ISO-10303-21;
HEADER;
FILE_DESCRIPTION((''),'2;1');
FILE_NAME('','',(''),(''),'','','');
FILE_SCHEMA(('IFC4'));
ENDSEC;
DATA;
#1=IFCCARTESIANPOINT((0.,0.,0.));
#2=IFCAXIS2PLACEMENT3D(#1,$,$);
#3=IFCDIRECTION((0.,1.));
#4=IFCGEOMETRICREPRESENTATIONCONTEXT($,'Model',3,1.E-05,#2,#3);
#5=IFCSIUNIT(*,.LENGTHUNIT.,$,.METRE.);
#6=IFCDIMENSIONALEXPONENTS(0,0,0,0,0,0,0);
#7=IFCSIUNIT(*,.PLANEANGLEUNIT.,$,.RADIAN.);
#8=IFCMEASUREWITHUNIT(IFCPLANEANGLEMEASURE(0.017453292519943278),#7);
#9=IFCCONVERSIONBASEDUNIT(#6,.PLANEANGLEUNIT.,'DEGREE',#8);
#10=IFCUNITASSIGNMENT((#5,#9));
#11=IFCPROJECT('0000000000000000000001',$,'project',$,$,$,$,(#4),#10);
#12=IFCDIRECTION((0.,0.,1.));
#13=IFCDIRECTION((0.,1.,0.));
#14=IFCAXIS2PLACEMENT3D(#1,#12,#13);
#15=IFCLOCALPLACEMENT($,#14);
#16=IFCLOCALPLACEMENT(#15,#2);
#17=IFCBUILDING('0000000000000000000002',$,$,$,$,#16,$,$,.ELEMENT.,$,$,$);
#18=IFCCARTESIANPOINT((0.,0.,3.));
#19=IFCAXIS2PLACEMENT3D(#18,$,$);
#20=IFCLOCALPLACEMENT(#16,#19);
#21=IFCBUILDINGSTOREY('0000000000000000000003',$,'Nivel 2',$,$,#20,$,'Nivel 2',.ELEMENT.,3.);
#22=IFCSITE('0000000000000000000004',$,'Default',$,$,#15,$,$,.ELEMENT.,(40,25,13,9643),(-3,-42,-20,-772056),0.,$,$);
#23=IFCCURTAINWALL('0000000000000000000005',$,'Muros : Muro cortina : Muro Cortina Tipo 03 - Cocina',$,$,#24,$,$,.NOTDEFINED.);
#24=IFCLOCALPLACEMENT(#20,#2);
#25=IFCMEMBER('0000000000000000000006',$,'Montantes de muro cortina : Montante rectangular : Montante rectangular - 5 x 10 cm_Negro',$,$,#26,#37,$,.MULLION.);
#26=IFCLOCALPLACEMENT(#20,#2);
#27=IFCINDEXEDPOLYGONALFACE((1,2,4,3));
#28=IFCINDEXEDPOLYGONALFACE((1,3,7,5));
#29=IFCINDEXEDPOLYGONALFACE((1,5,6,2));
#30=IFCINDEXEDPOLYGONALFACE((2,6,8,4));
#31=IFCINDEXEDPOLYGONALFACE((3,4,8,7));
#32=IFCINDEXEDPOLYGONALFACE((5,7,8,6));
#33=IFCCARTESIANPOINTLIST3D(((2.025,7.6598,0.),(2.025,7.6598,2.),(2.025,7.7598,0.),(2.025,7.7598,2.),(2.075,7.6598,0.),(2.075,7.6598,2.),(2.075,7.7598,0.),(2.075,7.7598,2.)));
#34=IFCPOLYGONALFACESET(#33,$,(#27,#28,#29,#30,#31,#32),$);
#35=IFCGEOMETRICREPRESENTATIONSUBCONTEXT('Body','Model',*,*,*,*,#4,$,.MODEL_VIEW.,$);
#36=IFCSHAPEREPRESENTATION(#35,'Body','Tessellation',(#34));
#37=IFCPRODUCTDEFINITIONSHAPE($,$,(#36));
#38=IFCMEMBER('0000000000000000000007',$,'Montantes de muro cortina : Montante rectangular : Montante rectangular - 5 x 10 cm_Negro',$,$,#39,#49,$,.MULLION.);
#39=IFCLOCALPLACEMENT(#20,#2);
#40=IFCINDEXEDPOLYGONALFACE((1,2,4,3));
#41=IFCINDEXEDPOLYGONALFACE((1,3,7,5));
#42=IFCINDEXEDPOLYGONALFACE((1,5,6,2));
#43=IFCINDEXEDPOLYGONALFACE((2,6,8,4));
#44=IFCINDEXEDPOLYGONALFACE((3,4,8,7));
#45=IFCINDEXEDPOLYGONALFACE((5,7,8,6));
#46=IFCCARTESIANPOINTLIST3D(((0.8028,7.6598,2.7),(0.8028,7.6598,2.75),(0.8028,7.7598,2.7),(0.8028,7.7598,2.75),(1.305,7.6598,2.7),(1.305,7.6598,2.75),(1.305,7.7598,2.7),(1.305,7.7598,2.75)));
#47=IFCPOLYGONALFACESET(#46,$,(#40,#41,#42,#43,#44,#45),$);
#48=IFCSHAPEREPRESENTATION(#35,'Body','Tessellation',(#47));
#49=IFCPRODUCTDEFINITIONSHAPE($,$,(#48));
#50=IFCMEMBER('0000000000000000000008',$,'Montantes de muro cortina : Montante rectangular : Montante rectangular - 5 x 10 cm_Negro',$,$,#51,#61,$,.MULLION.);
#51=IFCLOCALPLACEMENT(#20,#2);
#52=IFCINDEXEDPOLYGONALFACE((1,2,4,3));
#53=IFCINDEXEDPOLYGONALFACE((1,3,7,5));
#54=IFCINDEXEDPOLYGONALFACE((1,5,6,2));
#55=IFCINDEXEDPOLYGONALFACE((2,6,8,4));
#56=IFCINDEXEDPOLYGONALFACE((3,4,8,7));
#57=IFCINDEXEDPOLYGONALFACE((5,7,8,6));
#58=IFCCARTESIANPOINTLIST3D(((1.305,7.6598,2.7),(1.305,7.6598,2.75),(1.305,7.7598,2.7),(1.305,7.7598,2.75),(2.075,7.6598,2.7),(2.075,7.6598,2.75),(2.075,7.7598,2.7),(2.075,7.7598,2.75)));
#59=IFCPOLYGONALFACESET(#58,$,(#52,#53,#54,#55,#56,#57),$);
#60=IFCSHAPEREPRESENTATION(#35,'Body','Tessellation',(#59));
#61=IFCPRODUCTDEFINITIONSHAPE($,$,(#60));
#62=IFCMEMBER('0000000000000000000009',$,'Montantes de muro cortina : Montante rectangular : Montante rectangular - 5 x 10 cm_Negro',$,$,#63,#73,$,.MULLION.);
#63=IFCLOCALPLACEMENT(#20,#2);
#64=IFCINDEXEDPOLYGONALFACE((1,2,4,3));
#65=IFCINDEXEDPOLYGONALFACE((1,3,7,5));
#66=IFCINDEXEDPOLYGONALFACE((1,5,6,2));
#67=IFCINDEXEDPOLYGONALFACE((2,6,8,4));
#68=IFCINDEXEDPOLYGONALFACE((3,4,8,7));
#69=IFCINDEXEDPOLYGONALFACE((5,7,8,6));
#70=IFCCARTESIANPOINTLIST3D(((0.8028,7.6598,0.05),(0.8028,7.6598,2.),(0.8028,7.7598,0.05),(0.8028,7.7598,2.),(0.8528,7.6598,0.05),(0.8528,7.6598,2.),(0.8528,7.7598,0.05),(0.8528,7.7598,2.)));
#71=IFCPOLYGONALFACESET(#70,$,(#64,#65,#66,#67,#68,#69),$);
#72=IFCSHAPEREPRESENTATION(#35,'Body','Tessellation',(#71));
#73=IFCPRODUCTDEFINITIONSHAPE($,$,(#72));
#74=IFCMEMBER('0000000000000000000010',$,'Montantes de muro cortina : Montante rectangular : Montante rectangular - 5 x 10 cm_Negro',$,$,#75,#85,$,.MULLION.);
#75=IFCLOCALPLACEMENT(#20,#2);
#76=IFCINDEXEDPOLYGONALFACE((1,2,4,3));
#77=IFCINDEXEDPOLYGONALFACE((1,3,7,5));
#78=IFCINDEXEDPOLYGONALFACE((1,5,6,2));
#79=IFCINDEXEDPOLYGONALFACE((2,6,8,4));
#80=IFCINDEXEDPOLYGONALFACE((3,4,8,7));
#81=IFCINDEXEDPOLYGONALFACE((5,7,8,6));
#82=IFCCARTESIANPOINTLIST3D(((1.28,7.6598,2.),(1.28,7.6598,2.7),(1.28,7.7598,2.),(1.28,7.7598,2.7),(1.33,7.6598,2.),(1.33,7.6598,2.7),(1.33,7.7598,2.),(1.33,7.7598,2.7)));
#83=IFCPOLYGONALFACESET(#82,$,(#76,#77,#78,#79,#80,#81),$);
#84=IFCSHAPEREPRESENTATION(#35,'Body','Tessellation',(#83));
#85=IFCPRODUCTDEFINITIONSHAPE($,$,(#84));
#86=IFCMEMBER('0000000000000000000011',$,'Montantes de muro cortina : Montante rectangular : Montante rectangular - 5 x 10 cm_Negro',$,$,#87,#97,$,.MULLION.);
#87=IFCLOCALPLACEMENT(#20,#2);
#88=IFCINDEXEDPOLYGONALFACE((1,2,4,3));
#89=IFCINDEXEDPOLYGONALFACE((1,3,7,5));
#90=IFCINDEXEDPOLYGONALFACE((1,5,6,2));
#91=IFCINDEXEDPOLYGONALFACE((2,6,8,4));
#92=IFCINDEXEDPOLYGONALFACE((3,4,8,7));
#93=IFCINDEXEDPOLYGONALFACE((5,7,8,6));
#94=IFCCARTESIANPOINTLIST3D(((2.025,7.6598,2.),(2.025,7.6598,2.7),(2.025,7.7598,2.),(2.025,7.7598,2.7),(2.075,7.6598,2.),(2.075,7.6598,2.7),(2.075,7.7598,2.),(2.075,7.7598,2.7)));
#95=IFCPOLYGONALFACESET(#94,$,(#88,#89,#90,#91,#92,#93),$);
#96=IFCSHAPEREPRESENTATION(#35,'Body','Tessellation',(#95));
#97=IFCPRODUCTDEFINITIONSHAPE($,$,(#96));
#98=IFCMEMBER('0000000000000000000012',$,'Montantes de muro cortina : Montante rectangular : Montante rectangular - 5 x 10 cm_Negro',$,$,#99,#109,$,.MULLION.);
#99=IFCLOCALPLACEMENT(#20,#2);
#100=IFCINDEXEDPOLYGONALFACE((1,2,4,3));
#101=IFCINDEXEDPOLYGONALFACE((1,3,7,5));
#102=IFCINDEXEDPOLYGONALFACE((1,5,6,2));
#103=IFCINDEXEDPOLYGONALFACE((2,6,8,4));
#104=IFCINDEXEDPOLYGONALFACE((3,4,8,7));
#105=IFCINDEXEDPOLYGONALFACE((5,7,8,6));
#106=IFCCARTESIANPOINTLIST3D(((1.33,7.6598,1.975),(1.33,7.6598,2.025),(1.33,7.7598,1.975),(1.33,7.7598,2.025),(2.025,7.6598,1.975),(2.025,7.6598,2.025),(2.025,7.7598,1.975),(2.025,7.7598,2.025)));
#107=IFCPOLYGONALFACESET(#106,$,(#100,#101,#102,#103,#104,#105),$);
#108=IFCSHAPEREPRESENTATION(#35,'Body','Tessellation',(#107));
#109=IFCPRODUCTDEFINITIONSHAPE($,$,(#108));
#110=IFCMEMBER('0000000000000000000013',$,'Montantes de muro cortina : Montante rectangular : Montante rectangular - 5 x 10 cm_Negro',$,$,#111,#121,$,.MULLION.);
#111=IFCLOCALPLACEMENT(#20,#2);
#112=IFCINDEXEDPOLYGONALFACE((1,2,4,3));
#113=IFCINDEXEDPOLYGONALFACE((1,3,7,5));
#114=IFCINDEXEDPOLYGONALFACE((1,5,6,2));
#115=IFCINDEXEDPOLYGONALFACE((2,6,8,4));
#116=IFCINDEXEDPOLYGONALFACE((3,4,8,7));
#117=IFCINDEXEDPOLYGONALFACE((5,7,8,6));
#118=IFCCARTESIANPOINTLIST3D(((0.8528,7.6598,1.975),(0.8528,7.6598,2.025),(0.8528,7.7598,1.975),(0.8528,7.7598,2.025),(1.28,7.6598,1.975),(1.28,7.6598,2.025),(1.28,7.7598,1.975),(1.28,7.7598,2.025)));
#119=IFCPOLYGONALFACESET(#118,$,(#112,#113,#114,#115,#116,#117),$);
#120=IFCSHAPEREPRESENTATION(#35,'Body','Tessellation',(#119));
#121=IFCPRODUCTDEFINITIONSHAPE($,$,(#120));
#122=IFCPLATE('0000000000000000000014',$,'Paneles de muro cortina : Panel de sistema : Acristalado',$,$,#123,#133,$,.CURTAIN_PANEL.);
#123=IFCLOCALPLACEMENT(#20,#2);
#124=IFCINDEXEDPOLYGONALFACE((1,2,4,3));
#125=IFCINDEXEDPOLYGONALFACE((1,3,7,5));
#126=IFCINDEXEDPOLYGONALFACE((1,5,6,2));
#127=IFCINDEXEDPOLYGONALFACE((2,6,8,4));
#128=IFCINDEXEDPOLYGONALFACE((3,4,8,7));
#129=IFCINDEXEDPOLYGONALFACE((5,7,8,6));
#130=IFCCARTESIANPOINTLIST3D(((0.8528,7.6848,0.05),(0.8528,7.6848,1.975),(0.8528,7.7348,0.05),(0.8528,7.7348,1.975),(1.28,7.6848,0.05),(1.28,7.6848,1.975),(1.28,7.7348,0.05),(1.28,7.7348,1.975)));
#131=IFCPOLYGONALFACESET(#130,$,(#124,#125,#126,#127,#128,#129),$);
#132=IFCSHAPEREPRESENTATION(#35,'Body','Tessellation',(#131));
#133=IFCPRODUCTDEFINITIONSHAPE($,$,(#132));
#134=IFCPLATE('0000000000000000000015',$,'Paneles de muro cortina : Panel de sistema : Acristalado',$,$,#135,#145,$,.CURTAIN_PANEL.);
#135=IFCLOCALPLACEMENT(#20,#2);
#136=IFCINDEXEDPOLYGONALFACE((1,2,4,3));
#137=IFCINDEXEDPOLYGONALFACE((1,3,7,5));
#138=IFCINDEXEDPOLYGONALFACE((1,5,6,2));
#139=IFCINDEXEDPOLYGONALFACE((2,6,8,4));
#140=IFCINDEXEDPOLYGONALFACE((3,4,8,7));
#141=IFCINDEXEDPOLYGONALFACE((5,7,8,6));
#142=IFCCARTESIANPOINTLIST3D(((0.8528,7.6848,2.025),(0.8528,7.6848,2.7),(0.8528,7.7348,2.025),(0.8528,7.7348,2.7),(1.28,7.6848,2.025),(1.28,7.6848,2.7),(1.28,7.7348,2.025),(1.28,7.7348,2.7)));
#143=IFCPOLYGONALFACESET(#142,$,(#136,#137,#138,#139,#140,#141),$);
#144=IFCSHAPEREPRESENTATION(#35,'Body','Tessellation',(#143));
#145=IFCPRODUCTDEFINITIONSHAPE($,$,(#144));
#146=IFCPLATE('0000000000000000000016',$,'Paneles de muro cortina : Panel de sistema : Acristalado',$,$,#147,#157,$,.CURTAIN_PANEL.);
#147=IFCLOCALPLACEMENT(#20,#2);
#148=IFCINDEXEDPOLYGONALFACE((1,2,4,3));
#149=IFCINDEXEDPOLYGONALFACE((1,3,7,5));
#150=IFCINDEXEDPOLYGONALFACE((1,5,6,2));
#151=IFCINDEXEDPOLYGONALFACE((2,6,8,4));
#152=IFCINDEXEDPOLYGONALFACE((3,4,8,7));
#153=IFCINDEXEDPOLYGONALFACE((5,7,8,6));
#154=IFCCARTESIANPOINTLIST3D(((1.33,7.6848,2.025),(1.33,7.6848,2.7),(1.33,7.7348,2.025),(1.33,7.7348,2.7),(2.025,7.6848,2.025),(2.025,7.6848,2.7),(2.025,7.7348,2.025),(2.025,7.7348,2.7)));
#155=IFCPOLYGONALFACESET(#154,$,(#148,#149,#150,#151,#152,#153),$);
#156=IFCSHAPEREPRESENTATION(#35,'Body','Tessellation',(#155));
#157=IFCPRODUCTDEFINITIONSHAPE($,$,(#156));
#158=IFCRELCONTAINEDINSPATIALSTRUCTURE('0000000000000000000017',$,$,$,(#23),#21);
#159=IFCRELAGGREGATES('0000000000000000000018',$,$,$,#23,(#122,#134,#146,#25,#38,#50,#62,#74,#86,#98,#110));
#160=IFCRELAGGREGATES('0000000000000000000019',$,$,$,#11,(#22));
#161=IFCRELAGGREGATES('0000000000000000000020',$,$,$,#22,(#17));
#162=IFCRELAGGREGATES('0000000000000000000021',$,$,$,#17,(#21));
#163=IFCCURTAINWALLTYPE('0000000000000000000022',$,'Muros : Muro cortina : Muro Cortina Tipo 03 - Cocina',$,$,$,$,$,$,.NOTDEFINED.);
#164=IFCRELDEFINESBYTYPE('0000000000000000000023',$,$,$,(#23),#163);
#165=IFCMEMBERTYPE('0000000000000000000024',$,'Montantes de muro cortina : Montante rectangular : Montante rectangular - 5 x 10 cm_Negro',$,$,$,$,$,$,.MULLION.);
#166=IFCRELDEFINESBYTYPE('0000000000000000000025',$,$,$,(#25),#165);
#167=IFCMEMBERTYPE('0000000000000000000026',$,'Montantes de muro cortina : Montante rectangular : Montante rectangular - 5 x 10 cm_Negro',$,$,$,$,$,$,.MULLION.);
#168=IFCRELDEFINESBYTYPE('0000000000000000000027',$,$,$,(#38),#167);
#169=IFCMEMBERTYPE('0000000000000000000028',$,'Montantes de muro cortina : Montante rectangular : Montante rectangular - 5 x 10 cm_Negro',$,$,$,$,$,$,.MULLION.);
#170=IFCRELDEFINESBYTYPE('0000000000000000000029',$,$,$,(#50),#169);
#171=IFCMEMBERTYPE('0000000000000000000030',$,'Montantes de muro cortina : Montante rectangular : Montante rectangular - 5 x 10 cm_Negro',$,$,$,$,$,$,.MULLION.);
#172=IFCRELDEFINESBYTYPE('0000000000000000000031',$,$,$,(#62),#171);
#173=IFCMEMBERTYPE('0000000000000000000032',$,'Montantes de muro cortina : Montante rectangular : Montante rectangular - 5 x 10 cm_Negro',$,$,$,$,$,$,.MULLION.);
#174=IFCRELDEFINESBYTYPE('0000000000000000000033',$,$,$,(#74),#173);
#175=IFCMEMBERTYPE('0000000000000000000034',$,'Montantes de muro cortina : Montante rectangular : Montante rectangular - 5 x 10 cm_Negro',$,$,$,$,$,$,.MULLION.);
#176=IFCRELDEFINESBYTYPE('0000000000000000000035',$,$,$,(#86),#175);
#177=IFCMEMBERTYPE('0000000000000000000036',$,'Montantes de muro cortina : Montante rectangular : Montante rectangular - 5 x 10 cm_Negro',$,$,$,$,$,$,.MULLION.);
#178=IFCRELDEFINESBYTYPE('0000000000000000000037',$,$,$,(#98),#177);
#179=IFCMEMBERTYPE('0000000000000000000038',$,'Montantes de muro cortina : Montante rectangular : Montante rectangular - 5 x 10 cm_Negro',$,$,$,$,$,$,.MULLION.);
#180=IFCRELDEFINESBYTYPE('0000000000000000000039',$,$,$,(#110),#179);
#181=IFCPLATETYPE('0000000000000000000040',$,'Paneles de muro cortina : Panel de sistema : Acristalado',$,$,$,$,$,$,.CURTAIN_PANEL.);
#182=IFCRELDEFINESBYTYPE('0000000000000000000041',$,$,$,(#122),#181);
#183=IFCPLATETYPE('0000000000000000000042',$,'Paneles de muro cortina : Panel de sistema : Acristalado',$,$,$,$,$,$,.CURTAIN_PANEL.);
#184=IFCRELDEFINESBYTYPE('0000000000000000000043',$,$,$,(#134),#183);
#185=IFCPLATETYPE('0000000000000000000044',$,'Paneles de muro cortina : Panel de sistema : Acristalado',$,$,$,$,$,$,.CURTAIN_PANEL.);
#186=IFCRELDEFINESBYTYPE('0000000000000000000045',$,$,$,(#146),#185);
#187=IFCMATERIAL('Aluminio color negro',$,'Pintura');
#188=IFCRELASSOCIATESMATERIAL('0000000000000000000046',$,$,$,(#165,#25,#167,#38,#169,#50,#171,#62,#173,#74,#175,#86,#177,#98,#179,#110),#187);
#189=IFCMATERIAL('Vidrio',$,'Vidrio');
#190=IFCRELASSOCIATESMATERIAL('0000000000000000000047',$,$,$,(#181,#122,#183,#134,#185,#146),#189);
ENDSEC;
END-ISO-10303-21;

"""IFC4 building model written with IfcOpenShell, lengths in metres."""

from ifc_helpers import new_model, entity, si_unit, converted_unit, direction, frame, origin, place, context, subcontext, project, spatial, indexed_curve, outline, extrude, source, transform, mapped, material, type_object, type_shapes, element, aggregate, save


model = new_model("IFC4")

# Units and contexts
model_context = context("Model", 3, precision=1e-05, world=origin(), true_north=direction((0.0, 1.0)))
body_context = subcontext(model_context, "Body", "Model", "MODEL_VIEW")
ifc_project = project(units=[si_unit("LENGTHUNIT", "METRE"), converted_unit("PLANEANGLEUNIT", "DEGREE", entity("IfcPlaneAngleMeasure", 0.017453292519943278), si_unit("PLANEANGLEUNIT", "RADIAN"), dimensions=[0, 0, 0, 0, 0, 0, 0])], contexts=[model_context])

# Site, building, storey
site_placement = place(None, frame((0.0, 0.0, 0.0), z_axis=(0.0, 0.0, 1.0), x_axis=(0.0, 1.0, 0.0)))
site = spatial("IfcSite", under=ifc_project, at=site_placement, Name="Default", CompositionType="ELEMENT", RefLatitude=(40, 25, 13, 9643), RefLongitude=(-3, -42, -20, -772056), RefElevation=0.0)
building_placement = place(site_placement, origin())
building = spatial("IfcBuilding", under=site, at=building_placement, CompositionType="ELEMENT")
storey_placement = place(building_placement, frame((0.0, 0.0, 3.0)))
storey = spatial("IfcBuildingStorey", under=building, at=storey_placement, Name="Nivel 2", LongName="Nivel 2", CompositionType="ELEMENT", Elevation=3.0)

# Curtain wall, members, plates
curtain_wall_type_1 = type_object("IfcCurtainWallType", Name="Muros : Muro cortina : Muro Cortina Tipo 03 - Cocina", PredefinedType="NOTDEFINED")
curtain_wall_1_placement = place(storey_placement, frame((0.0, 0.0, -3.0)))
curtain_wall_1 = element("IfcCurtainWall", 1, at=curtain_wall_1_placement, inside=storey, type_object=curtain_wall_type_1, Name="Muros : Muro cortina : Muro Cortina Tipo 03 - Cocina", PredefinedType="NOTDEFINED")
ifc_material_1 = material(Name="Aluminio color negro", Category="Pintura")
member_type_1 = type_object("IfcMemberType", Name="Montantes de muro cortina : Montante rectangular : Montante rectangular - 5 x 10 cm_Negro", PredefinedType="MULLION", material=ifc_material_1)
shared_shape_1 = source(origin(), body_context, "Body", "SweptSolid", [
    extrude(outline(indexed_curve([(-0.025, -0.05), (0.025, -0.05), (0.025, 0.05), (-0.025, 0.05), (-0.025, -0.05)], self_intersect=False)), frame((-0.025, 0.0, -2.0), z_axis=(0.0, 0.0, 1.0), x_axis=(-1.0, 0.0, 0.0)), (0.0, 0.0, 1.0), 2.0),
])
type_shapes(member_type_1, [shared_shape_1])
member_1_placement = place(curtain_wall_1_placement, frame((2.075, 7.7098, 3.0), z_axis=(0.0, 0.0, -1.0), x_axis=(1.0, 0.0, 0.0)))
member_1 = element("IfcMember", 2, at=member_1_placement, type_object=member_type_1, material=ifc_material_1, Name="Montantes de muro cortina : Montante rectangular : Montante rectangular - 5 x 10 cm_Negro", PredefinedType="MULLION", context=body_context, shape_type="MappedRepresentation", body=[
    mapped(shared_shape_1, transform((0.0, 0.0, 0.0), scale=1.0)),
])
member_type_2 = type_object("IfcMemberType", Name="Montantes de muro cortina : Montante rectangular : Montante rectangular - 5 x 10 cm_Negro", PredefinedType="MULLION", material=ifc_material_1)
shared_shape_2 = source(origin(), body_context, "Body", "SweptSolid", [
    extrude(outline(indexed_curve([(-0.025, -0.05), (0.025, -0.05), (0.025, 0.05), (-0.025, 0.05), (-0.025, -0.05)], self_intersect=False)), frame((-0.025, 0.0, -0.5022), z_axis=(0.0, 0.0, 1.0), x_axis=(-1.0, 0.0, 0.0)), (0.0, 0.0, 1.0), 0.5022),
])
type_shapes(member_type_2, [shared_shape_2])
member_2_placement = place(curtain_wall_1_placement, frame((1.305, 7.7098, 5.75), z_axis=(1.0, 0.0, 0.0), x_axis=(0.0, 0.0, 1.0)))
member_2 = element("IfcMember", 3, at=member_2_placement, type_object=member_type_2, material=ifc_material_1, Name="Montantes de muro cortina : Montante rectangular : Montante rectangular - 5 x 10 cm_Negro", PredefinedType="MULLION", context=body_context, shape_type="MappedRepresentation", body=[
    mapped(shared_shape_2, transform((0.0, 0.0, 0.0), scale=1.0)),
])
member_type_3 = type_object("IfcMemberType", Name="Montantes de muro cortina : Montante rectangular : Montante rectangular - 5 x 10 cm_Negro", PredefinedType="MULLION", material=ifc_material_1)
shared_shape_3 = source(origin(), body_context, "Body", "SweptSolid", [
    extrude(outline(indexed_curve([(-0.025, -0.05), (0.025, -0.05), (0.025, 0.05), (-0.025, 0.05), (-0.025, -0.05)], self_intersect=False)), frame((-0.025, 0.0, -0.77), z_axis=(0.0, 0.0, 1.0), x_axis=(-1.0, 0.0, 0.0)), (0.0, 0.0, 1.0), 0.77),
])
type_shapes(member_type_3, [shared_shape_3])
member_3_placement = place(curtain_wall_1_placement, frame((2.075, 7.7098, 5.75), z_axis=(1.0, 0.0, 0.0), x_axis=(0.0, 0.0, 1.0)))
member_3 = element("IfcMember", 4, at=member_3_placement, type_object=member_type_3, material=ifc_material_1, Name="Montantes de muro cortina : Montante rectangular : Montante rectangular - 5 x 10 cm_Negro", PredefinedType="MULLION", context=body_context, shape_type="MappedRepresentation", body=[
    mapped(shared_shape_3, transform((0.0, 0.0, 0.0), scale=1.0)),
])
member_type_4 = type_object("IfcMemberType", Name="Montantes de muro cortina : Montante rectangular : Montante rectangular - 5 x 10 cm_Negro", PredefinedType="MULLION", material=ifc_material_1)
shared_shape_4 = source(origin(), body_context, "Body", "SweptSolid", [
    extrude(outline(indexed_curve([(-0.05, -0.025), (0.05, -0.025), (0.05, 0.025), (-0.05, 0.025), (-0.05, -0.025)], self_intersect=False)), frame((-0.025, 0.0, -1.95), z_axis=(0.0, 0.0, 1.0), x_axis=(0.0, -1.0, 0.0)), (0.0, 0.0, 1.0), 1.95),
])
type_shapes(member_type_4, [shared_shape_4])
member_4_placement = place(curtain_wall_1_placement, frame((0.8028, 7.7098, 5.0), z_axis=(0.0, 0.0, 1.0), x_axis=(-1.0, 0.0, 0.0)))
member_4 = element("IfcMember", 5, at=member_4_placement, type_object=member_type_4, material=ifc_material_1, Name="Montantes de muro cortina : Montante rectangular : Montante rectangular - 5 x 10 cm_Negro", PredefinedType="MULLION", context=body_context, shape_type="MappedRepresentation", body=[
    mapped(shared_shape_4, transform((0.0, 0.0, 0.0), scale=1.0)),
])
member_type_5 = type_object("IfcMemberType", Name="Montantes de muro cortina : Montante rectangular : Montante rectangular - 5 x 10 cm_Negro", PredefinedType="MULLION", material=ifc_material_1)
shared_shape_5 = source(origin(), body_context, "Body", "SweptSolid", [
    extrude(outline(indexed_curve([(-0.025, -0.05), (0.025, -0.05), (0.025, 0.05), (-0.025, 0.05), (-0.025, -0.05)], self_intersect=False)), frame((0.0, 0.0, -0.7), z_axis=(0.0, 0.0, 1.0), x_axis=(-1.0, 0.0, 0.0)), (0.0, 0.0, 1.0), 0.7),
])
type_shapes(member_type_5, [shared_shape_5])
member_5_placement = place(curtain_wall_1_placement, frame((1.305, 7.7098, 5.0), z_axis=(0.0, 0.0, -1.0), x_axis=(1.0, 0.0, 0.0)))
member_5 = element("IfcMember", 6, at=member_5_placement, type_object=member_type_5, material=ifc_material_1, Name="Montantes de muro cortina : Montante rectangular : Montante rectangular - 5 x 10 cm_Negro", PredefinedType="MULLION", context=body_context, shape_type="MappedRepresentation", body=[
    mapped(shared_shape_5, transform((0.0, 0.0, 0.0), scale=1.0)),
])
member_type_6 = type_object("IfcMemberType", Name="Montantes de muro cortina : Montante rectangular : Montante rectangular - 5 x 10 cm_Negro", PredefinedType="MULLION", material=ifc_material_1)
shared_shape_6 = source(origin(), body_context, "Body", "SweptSolid", [
    extrude(outline(indexed_curve([(-0.025, -0.05), (0.025, -0.05), (0.025, 0.05), (-0.025, 0.05), (-0.025, -0.05)], self_intersect=False)), frame((-0.025, 0.0, -0.7), z_axis=(0.0, 0.0, 1.0), x_axis=(-1.0, 0.0, 0.0)), (0.0, 0.0, 1.0), 0.7),
])
type_shapes(member_type_6, [shared_shape_6])
member_6_placement = place(curtain_wall_1_placement, frame((2.075, 7.7098, 5.0), z_axis=(0.0, 0.0, -1.0), x_axis=(1.0, 0.0, 0.0)))
member_6 = element("IfcMember", 7, at=member_6_placement, type_object=member_type_6, material=ifc_material_1, Name="Montantes de muro cortina : Montante rectangular : Montante rectangular - 5 x 10 cm_Negro", PredefinedType="MULLION", context=body_context, shape_type="MappedRepresentation", body=[
    mapped(shared_shape_6, transform((0.0, 0.0, 0.0), scale=1.0)),
])
member_type_7 = type_object("IfcMemberType", Name="Montantes de muro cortina : Montante rectangular : Montante rectangular - 5 x 10 cm_Negro", PredefinedType="MULLION", material=ifc_material_1)
shared_shape_7 = source(origin(), body_context, "Body", "SweptSolid", [
    extrude(outline(indexed_curve([(-0.025, -0.05), (0.025, -0.05), (0.025, 0.05), (-0.025, 0.05), (-0.025, -0.05)], self_intersect=False)), frame((0.0, 0.0, -0.695), z_axis=(0.0, 0.0, 1.0), x_axis=(-1.0, 0.0, 0.0)), (0.0, 0.0, 1.0), 0.695),
])
type_shapes(member_type_7, [shared_shape_7])
member_7_placement = place(curtain_wall_1_placement, frame((2.025, 7.7098, 5.0), z_axis=(1.0, 0.0, 0.0), x_axis=(0.0, 0.0, 1.0)))
member_7 = element("IfcMember", 8, at=member_7_placement, type_object=member_type_7, material=ifc_material_1, Name="Montantes de muro cortina : Montante rectangular : Montante rectangular - 5 x 10 cm_Negro", PredefinedType="MULLION", context=body_context, shape_type="MappedRepresentation", body=[
    mapped(shared_shape_7, transform((0.0, 0.0, 0.0), scale=1.0)),
])
member_type_8 = type_object("IfcMemberType", Name="Montantes de muro cortina : Montante rectangular : Montante rectangular - 5 x 10 cm_Negro", PredefinedType="MULLION", material=ifc_material_1)
shared_shape_8 = source(origin(), body_context, "Body", "SweptSolid", [
    extrude(outline(indexed_curve([(-0.025, -0.05), (0.025, -0.05), (0.025, 0.05), (-0.025, 0.05), (-0.025, -0.05)], self_intersect=False)), frame((0.0, 0.0, -0.4272), z_axis=(0.0, 0.0, 1.0), x_axis=(-1.0, 0.0, 0.0)), (0.0, 0.0, 1.0), 0.4272),
])
type_shapes(member_type_8, [shared_shape_8])
member_8_placement = place(curtain_wall_1_placement, frame((1.28, 7.7098, 5.0), z_axis=(1.0, 0.0, 0.0), x_axis=(0.0, 0.0, 1.0)))
member_8 = element("IfcMember", 9, at=member_8_placement, type_object=member_type_8, material=ifc_material_1, Name="Montantes de muro cortina : Montante rectangular : Montante rectangular - 5 x 10 cm_Negro", PredefinedType="MULLION", context=body_context, shape_type="MappedRepresentation", body=[
    mapped(shared_shape_8, transform((0.0, 0.0, 0.0), scale=1.0)),
])
ifc_material_2 = material(Name="Vidrio", Category="Vidrio")
plate_type_1 = type_object("IfcPlateType", Name="Paneles de muro cortina : Panel de sistema : Acristalado", PredefinedType="CURTAIN_PANEL", material=ifc_material_2)
shared_shape_9 = source(origin(), body_context, "Body", "SweptSolid", [
    extrude(outline(indexed_curve([(-0.025, -0.2136), (0.025, -0.2136), (0.025, 0.2136), (-0.025, 0.2136), (-0.025, -0.2136)], self_intersect=False)), frame((0.0, 0.0, 0.0), z_axis=(0.0, 0.0, 1.0), x_axis=(0.0, 1.0, 0.0)), (0.0, 0.0, 1.0), 1.925),
])
type_shapes(plate_type_1, [shared_shape_9])
plate_1_placement = place(curtain_wall_1_placement, frame((1.0664, 7.7098, 3.05)))
plate_1 = element("IfcPlate", 10, at=plate_1_placement, type_object=plate_type_1, material=ifc_material_2, Name="Paneles de muro cortina : Panel de sistema : Acristalado", PredefinedType="CURTAIN_PANEL", context=body_context, shape_type="MappedRepresentation", body=[
    mapped(shared_shape_9, transform((0.0, 0.0, 0.0), scale=1.0)),
])
plate_type_2 = type_object("IfcPlateType", Name="Paneles de muro cortina : Panel de sistema : Acristalado", PredefinedType="CURTAIN_PANEL", material=ifc_material_2)
shared_shape_10 = source(origin(), body_context, "Body", "SweptSolid", [
    extrude(outline(indexed_curve([(-0.025, -0.2136), (0.025, -0.2136), (0.025, 0.2136), (-0.025, 0.2136), (-0.025, -0.2136)], self_intersect=False)), frame((0.0, 0.0, 0.0), z_axis=(0.0, 0.0, 1.0), x_axis=(0.0, 1.0, 0.0)), (0.0, 0.0, 1.0), 0.675),
])
type_shapes(plate_type_2, [shared_shape_10])
plate_2_placement = place(curtain_wall_1_placement, frame((1.0664, 7.7098, 5.025)))
plate_2 = element("IfcPlate", 11, at=plate_2_placement, type_object=plate_type_2, material=ifc_material_2, Name="Paneles de muro cortina : Panel de sistema : Acristalado", PredefinedType="CURTAIN_PANEL", context=body_context, shape_type="MappedRepresentation", body=[
    mapped(shared_shape_10, transform((0.0, 0.0, 0.0), scale=1.0)),
])
plate_type_3 = type_object("IfcPlateType", Name="Paneles de muro cortina : Panel de sistema : Acristalado", PredefinedType="CURTAIN_PANEL", material=ifc_material_2)
shared_shape_11 = source(origin(), body_context, "Body", "SweptSolid", [
    extrude(outline(indexed_curve([(-0.025, -0.3475), (0.025, -0.3475), (0.025, 0.3475), (-0.025, 0.3475), (-0.025, -0.3475)], self_intersect=False)), frame((0.0, 0.0, 0.0), z_axis=(0.0, 0.0, 1.0), x_axis=(0.0, 1.0, 0.0)), (0.0, 0.0, 1.0), 0.675),
])
type_shapes(plate_type_3, [shared_shape_11])
plate_3_placement = place(curtain_wall_1_placement, frame((1.6775, 7.7098, 5.025)))
plate_3 = element("IfcPlate", 12, at=plate_3_placement, type_object=plate_type_3, material=ifc_material_2, Name="Paneles de muro cortina : Panel de sistema : Acristalado", PredefinedType="CURTAIN_PANEL", context=body_context, shape_type="MappedRepresentation", body=[
    mapped(shared_shape_11, transform((0.0, 0.0, 0.0), scale=1.0)),
])

aggregate(curtain_wall_1, [plate_1, plate_2, plate_3, member_1, member_2, member_3, member_4, member_5, member_6, member_7, member_8])

save(model, "model.ifc")
